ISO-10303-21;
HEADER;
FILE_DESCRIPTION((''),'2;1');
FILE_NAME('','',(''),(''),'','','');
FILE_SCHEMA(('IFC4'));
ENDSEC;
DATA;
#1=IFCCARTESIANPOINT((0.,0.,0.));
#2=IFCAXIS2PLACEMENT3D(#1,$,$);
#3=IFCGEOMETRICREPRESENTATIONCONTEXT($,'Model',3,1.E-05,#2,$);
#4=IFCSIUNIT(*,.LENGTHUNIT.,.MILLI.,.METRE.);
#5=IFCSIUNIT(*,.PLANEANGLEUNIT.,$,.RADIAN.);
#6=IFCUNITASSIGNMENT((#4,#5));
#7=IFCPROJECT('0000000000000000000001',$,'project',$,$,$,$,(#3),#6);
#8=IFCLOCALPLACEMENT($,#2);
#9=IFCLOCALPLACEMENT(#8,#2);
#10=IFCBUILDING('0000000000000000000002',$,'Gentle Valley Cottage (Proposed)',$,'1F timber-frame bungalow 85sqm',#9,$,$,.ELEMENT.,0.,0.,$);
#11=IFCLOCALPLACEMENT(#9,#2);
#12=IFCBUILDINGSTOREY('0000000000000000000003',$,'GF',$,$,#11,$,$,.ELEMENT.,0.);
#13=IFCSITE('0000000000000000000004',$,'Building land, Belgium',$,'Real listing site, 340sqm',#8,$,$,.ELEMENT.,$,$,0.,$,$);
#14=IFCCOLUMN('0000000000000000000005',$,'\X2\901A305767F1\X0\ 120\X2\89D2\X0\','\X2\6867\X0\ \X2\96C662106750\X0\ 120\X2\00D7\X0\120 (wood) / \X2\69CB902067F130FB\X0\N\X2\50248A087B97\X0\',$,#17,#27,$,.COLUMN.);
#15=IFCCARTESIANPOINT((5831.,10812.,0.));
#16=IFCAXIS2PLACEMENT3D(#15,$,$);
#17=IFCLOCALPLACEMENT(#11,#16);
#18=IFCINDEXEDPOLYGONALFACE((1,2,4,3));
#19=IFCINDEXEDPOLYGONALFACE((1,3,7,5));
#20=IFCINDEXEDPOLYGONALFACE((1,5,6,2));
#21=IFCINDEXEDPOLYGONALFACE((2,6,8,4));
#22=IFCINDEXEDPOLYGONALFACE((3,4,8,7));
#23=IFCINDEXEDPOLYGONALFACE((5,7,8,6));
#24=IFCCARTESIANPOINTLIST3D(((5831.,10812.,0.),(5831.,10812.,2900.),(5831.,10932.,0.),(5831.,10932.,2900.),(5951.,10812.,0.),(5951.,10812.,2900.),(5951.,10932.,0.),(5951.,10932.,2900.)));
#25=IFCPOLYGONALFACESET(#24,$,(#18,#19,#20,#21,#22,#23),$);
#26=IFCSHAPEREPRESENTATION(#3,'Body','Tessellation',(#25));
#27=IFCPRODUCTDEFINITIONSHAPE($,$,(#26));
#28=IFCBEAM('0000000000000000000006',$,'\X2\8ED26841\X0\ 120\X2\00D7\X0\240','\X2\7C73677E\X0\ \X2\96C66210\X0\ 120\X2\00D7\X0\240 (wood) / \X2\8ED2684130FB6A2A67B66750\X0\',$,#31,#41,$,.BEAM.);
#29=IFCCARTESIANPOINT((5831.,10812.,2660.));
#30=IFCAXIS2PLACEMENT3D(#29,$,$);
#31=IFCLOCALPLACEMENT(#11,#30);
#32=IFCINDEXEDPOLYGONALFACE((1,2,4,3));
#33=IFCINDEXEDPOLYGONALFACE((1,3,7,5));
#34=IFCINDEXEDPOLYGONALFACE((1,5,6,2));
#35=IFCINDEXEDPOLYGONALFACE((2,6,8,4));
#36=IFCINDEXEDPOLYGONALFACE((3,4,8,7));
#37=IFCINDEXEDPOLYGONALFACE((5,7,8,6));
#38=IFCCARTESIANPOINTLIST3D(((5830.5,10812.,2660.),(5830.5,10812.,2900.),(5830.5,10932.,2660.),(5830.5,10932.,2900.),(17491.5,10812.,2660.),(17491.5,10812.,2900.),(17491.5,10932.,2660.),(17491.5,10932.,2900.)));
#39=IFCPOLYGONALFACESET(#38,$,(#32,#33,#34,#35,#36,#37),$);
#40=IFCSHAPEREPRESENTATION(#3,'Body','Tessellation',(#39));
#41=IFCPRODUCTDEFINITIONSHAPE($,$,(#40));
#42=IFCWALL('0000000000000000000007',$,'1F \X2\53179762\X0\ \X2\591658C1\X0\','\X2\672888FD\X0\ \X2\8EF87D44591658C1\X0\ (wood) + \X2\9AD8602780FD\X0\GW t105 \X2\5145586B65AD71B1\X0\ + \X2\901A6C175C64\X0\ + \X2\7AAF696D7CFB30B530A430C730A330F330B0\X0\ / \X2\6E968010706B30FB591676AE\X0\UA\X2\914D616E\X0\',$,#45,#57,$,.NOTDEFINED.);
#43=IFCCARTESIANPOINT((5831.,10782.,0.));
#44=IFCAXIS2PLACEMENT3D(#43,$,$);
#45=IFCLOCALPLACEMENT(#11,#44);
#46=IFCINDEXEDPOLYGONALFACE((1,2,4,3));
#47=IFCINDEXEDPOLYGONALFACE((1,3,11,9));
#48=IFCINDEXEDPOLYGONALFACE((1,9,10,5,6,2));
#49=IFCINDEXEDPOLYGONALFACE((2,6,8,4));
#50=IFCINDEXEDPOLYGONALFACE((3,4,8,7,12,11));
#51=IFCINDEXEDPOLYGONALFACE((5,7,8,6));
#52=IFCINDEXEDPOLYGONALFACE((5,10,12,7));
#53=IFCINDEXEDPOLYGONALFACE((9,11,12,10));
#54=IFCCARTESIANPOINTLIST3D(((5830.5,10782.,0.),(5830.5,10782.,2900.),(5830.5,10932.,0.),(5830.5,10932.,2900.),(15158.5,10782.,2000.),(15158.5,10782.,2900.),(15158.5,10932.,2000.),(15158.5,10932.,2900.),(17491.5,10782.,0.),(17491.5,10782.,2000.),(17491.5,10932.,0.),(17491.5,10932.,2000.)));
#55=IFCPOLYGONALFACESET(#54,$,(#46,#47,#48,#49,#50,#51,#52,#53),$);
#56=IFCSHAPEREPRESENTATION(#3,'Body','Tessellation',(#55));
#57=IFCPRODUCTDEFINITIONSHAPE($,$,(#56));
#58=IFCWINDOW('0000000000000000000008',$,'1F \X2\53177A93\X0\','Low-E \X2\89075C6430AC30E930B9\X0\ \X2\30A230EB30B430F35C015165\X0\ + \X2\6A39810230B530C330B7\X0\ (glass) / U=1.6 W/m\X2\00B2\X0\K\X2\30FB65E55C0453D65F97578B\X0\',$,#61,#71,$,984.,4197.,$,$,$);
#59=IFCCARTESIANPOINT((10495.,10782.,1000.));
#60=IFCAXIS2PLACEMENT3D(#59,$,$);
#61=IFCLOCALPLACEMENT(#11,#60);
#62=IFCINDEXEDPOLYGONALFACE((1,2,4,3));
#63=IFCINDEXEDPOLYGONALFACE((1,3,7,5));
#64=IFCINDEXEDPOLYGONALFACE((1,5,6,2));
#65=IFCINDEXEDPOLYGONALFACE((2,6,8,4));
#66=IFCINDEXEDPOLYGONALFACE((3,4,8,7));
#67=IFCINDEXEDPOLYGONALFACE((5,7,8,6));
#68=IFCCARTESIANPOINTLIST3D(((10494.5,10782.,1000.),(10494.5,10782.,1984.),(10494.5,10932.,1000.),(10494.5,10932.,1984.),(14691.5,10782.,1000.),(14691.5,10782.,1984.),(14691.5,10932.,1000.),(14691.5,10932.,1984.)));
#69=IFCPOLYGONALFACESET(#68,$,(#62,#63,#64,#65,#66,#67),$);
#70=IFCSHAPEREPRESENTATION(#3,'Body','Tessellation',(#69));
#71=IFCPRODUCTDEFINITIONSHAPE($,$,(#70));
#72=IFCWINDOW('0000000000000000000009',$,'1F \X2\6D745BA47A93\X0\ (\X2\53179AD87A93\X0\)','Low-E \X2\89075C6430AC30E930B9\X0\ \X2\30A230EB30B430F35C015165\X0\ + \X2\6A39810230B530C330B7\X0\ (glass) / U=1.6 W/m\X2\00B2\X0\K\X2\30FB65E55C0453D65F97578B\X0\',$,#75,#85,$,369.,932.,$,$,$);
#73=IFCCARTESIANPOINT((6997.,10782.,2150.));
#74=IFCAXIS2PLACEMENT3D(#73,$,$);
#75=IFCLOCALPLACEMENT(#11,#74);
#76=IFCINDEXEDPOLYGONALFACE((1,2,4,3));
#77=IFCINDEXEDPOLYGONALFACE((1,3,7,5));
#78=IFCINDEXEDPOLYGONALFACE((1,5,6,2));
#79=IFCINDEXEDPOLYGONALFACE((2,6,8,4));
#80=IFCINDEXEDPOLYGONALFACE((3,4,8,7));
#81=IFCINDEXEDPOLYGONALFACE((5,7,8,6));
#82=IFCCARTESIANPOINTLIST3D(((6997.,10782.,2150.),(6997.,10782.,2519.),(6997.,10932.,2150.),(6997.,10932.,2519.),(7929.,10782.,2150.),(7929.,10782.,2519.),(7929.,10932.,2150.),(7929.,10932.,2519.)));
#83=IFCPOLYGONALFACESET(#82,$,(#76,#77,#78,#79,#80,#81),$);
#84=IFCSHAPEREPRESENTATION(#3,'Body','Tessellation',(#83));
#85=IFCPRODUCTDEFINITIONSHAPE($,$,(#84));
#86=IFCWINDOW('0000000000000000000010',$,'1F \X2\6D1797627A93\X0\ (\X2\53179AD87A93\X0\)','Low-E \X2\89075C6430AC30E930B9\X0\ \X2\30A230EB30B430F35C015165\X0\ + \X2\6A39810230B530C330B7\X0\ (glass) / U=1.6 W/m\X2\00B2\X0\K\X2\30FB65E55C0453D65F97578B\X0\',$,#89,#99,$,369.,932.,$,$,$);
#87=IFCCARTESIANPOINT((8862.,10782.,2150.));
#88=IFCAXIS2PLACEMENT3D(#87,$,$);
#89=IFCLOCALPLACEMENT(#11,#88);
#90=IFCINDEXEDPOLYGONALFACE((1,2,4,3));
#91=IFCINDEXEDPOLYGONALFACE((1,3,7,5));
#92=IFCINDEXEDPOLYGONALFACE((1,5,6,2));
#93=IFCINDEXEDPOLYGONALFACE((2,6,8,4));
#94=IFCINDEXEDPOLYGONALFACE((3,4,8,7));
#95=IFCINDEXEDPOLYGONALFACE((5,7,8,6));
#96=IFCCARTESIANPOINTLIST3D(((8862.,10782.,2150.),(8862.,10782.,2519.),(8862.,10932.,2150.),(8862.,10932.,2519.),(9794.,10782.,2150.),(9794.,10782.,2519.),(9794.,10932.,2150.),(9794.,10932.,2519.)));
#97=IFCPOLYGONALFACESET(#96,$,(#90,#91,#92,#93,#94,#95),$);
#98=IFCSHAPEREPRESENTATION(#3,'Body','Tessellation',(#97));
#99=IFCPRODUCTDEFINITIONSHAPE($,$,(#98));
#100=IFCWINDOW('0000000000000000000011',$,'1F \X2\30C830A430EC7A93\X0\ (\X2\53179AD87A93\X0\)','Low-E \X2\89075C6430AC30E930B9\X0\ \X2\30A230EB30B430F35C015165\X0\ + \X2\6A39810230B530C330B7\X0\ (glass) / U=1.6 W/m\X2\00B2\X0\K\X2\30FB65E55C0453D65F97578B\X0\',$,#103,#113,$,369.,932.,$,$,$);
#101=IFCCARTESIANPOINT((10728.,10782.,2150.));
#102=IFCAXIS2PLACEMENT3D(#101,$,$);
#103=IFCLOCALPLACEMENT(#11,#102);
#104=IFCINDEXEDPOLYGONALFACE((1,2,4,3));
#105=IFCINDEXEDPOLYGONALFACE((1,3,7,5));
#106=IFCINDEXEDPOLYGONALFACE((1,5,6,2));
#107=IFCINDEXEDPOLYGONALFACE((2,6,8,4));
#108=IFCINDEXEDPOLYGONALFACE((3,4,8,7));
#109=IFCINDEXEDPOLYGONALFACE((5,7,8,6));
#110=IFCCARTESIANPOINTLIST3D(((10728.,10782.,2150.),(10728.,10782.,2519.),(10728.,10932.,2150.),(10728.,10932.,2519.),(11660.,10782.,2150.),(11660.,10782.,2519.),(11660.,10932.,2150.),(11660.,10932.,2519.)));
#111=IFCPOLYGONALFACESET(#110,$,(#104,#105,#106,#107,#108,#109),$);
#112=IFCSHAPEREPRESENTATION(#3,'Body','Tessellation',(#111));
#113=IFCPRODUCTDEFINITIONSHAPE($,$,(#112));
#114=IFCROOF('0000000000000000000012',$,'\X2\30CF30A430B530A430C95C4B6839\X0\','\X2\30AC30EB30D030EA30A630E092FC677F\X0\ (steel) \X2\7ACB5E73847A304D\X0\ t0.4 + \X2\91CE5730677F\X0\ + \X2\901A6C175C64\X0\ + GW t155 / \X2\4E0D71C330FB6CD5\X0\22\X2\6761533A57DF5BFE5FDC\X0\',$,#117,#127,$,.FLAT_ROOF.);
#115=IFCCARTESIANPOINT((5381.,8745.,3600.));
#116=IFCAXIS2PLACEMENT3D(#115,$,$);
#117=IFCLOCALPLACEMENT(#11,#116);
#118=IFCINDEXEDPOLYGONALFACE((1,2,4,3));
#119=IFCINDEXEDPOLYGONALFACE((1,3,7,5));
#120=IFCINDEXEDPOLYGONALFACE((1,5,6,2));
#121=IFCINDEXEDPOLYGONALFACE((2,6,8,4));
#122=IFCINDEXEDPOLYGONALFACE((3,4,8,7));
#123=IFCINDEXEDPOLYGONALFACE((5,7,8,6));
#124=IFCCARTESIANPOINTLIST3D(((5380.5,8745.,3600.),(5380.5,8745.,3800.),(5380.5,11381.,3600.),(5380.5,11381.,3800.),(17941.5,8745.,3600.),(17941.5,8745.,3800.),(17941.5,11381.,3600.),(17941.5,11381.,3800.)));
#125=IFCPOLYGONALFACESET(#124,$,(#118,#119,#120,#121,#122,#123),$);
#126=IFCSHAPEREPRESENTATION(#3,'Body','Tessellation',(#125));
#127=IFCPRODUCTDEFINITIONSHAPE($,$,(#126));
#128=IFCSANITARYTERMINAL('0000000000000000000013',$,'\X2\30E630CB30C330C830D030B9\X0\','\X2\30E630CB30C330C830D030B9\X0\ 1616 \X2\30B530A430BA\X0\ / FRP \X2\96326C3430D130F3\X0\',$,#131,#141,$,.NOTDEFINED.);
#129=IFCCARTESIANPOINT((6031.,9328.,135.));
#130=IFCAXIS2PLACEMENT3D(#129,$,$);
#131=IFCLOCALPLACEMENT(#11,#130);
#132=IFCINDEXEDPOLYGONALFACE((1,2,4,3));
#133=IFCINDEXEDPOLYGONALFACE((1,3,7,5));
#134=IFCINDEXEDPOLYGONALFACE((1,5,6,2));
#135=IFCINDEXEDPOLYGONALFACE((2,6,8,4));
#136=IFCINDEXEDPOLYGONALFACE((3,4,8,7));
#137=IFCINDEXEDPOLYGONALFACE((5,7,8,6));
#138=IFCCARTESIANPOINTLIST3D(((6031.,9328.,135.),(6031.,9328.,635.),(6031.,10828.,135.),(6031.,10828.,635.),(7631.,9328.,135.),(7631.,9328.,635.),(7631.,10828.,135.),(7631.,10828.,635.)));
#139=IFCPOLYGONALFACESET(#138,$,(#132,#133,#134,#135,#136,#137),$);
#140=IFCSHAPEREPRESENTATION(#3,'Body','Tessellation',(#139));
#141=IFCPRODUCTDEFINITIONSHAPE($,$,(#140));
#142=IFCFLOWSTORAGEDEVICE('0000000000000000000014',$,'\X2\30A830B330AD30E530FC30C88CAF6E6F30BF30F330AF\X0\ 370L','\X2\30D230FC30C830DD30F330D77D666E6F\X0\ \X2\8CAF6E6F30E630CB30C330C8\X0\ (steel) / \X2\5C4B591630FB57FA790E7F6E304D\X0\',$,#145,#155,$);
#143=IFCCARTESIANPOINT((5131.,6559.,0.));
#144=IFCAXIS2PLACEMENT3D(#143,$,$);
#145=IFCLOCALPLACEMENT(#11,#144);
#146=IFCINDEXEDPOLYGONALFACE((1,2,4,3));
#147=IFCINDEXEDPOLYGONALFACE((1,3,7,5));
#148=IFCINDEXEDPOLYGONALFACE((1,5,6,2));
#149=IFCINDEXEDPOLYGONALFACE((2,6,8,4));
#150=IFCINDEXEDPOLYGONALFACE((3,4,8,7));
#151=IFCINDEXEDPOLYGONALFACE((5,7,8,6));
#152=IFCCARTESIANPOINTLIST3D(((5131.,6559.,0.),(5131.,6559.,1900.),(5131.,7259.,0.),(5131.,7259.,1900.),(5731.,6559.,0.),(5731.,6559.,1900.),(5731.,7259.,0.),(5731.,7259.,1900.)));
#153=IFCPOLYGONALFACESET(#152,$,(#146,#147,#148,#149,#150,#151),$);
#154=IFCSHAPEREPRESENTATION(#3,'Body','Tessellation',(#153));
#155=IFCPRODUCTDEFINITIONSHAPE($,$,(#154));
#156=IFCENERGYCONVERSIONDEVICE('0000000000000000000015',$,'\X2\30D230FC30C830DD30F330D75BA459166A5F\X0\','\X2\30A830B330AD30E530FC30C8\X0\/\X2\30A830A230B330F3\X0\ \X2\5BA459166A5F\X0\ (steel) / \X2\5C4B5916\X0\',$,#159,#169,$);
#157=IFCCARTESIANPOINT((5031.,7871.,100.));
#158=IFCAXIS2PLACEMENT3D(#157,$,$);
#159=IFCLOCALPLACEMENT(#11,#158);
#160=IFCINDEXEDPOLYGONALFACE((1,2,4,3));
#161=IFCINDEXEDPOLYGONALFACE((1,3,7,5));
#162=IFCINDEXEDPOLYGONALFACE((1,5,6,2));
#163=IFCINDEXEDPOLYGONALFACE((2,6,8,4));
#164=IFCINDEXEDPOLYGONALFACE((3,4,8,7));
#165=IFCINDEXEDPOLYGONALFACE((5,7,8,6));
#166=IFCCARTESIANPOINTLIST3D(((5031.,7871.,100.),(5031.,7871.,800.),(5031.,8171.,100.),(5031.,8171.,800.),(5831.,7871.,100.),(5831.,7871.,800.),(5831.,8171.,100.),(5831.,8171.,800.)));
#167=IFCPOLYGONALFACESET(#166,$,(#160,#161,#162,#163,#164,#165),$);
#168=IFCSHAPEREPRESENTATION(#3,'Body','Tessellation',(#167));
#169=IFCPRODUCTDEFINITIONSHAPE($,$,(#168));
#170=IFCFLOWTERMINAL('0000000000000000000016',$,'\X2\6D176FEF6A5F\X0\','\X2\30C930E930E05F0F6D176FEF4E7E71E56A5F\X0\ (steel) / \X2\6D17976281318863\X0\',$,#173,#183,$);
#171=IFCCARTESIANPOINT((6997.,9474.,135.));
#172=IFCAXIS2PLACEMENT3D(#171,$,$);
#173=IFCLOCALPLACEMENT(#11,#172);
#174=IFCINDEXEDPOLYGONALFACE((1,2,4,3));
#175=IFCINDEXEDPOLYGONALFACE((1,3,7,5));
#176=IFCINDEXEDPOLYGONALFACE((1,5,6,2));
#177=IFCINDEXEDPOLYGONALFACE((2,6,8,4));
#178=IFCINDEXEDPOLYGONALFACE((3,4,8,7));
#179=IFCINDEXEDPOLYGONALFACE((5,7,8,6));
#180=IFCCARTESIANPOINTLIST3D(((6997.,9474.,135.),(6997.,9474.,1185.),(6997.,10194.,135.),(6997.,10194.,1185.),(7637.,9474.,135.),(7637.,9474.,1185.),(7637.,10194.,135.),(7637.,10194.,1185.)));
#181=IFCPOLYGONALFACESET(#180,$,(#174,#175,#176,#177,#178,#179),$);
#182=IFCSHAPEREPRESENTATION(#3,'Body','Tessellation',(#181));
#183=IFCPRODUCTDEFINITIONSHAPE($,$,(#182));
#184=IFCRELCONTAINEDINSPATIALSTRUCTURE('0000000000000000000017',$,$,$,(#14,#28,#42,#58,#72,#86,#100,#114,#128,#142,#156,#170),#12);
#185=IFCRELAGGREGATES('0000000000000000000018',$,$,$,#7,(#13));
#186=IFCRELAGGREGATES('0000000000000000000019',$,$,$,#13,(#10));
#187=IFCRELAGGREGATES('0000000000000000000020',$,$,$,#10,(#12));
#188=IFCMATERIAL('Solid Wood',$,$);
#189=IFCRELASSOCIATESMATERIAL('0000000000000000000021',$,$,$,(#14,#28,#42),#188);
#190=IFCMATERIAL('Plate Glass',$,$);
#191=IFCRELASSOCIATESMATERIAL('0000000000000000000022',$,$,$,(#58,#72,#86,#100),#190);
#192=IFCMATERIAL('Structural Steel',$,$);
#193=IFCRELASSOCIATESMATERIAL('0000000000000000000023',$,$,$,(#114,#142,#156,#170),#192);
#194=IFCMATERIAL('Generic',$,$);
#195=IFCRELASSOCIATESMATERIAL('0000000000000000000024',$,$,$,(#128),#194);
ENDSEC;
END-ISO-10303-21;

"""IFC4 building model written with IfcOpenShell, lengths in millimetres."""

from ifc_helpers import new_model, si_unit, frame, frame_2d, origin, place, context, project, spatial, rectangle, extrude, material, element, fill, save


model = new_model("IFC4")

# Units and contexts
model_context = context("Model", 3, precision=1e-05, world=origin())
ifc_project = project(units=[si_unit("LENGTHUNIT", "METRE", prefix="MILLI"), si_unit("PLANEANGLEUNIT", "RADIAN")], contexts=[model_context])

# Site, building, storey
site_placement = place(None, origin())
site = spatial("IfcSite", under=ifc_project, at=site_placement, Name="Building land, Belgium", ObjectType="Real listing site, 340sqm", CompositionType="ELEMENT", RefElevation=0.0)
building_placement = place(site_placement, origin())
building = spatial("IfcBuilding", under=site, at=building_placement, Name="Gentle Valley Cottage (Proposed)", ObjectType="1F timber-frame bungalow 85sqm", CompositionType="ELEMENT", ElevationOfRefHeight=0.0, ElevationOfTerrain=0.0)
storey_placement = place(building_placement, origin())
storey = spatial("IfcBuildingStorey", under=building, at=storey_placement, Name="GF", CompositionType="ELEMENT", Elevation=0.0)

# Column
ifc_material_1 = material(Name="Solid Wood")
column_1_placement = place(storey_placement, frame((5831.0, 10812.0, 0.0)))
element("IfcColumn", 1, at=column_1_placement, inside=storey, material=ifc_material_1, Name="通し柱 120角", Description="桧 集成材 120×120 (wood) / 構造柱・N値計算", PredefinedType="COLUMN", context=model_context, shape_type="SweptSolid", body=[
    extrude(rectangle(XDim=120.0, YDim=120.0, at=frame_2d((60.0, 60.0))), frame((5831.0, 10812.0, 0.0)), (0.0, 0.0, 1.0), 2900.0),
])

# Beam
beam_1_placement = place(storey_placement, frame((5831.0, 10812.0, 2660.0)))
element("IfcBeam", 2, at=beam_1_placement, inside=storey, material=ifc_material_1, Name="軒桁 120×240", Description="米松 集成 120×240 (wood) / 軒桁・横架材", PredefinedType="BEAM", context=model_context, shape_type="SweptSolid", body=[
    extrude(rectangle(XDim=11661.0, YDim=120.0, at=frame_2d((5830.0, 60.0))), frame((5831.0, 10812.0, 2660.0)), (0.0, 0.0, 1.0), 240.0),
])

# Wall, openings, windows
wall_1_placement = place(storey_placement, frame((5831.0, 10782.0, 0.0)))
wall_1 = element("IfcWall", 3, at=wall_1_placement, inside=storey, material=ifc_material_1, Name="1F 北面 外壁", Description="木製 軸組外壁 (wood) + 高性能GW t105 充填断熱 + 通気層 + 窯業系サイディング / 準耐火・外皮UA配慮", PredefinedType="NOTDEFINED", context=model_context, shape_type="SweptSolid", body=[
    extrude(rectangle(XDim=11661.0, YDim=150.0, at=frame_2d((5830.0, 75.0))), frame((5831.0, 10782.0, 0.0)), (0.0, 0.0, 1.0), 2900.0),
])
opening_1_placement = place(storey_placement, frame((10495.0, 10782.0, 1000.0)))
opening_1 = element("IfcOpeningElement", 4, at=opening_1_placement, cuts=wall_1, PredefinedType="NOTDEFINED", context=model_context, shape_type="SweptSolid", body=[
    extrude(rectangle(XDim=4197.0, YDim=150.0, at=frame_2d((2098.0, 75.0))), frame((10495.0, 10782.0, 1000.0)), (0.0, 0.0, 1.0), 984.0),
])
opening_2_placement = place(storey_placement, frame((6997.0, 10782.0, 2150.0)))
opening_2 = element("IfcOpeningElement", 5, at=opening_2_placement, cuts=wall_1, PredefinedType="NOTDEFINED", context=model_context, shape_type="SweptSolid", body=[
    extrude(rectangle(XDim=932.0, YDim=150.0, at=frame_2d((466.0, 75.0))), frame((6997.0, 10782.0, 2150.0)), (0.0, 0.0, 1.0), 369.0),
])
opening_3_placement = place(storey_placement, frame((8862.0, 10782.0, 2150.0)))
opening_3 = element("IfcOpeningElement", 6, at=opening_3_placement, cuts=wall_1, PredefinedType="NOTDEFINED", context=model_context, shape_type="SweptSolid", body=[
    extrude(rectangle(XDim=932.0, YDim=150.0, at=frame_2d((466.0, 75.0))), frame((8862.0, 10782.0, 2150.0)), (0.0, 0.0, 1.0), 369.0),
])
opening_4_placement = place(storey_placement, frame((10728.0, 10782.0, 2150.0)))
opening_4 = element("IfcOpeningElement", 7, at=opening_4_placement, cuts=wall_1, PredefinedType="NOTDEFINED", context=model_context, shape_type="SweptSolid", body=[
    extrude(rectangle(XDim=932.0, YDim=150.0, at=frame_2d((466.0, 75.0))), frame((10728.0, 10782.0, 2150.0)), (0.0, 0.0, 1.0), 369.0),
])
ifc_material_2 = material(Name="Plate Glass")
window_1_placement = place(storey_placement, frame((10495.0, 10782.0, 1000.0)))
window_1 = element("IfcWindow", 8, at=window_1_placement, inside=storey, material=ifc_material_2, Name="1F 北窓", Description="Low-E 複層ガラス アルゴン封入 + 樹脂サッシ (glass) / U=1.6 W/m²K・日射取得型", OverallHeight=984.0, OverallWidth=4197.0, context=model_context, shape_type="SweptSolid", body=[
    extrude(rectangle(XDim=4197.0, YDim=150.0, at=frame_2d((2098.0, 75.0))), frame((10495.0, 10782.0, 1000.0)), (0.0, 0.0, 1.0), 984.0),
])
fill(opening_1, window_1)
window_2_placement = place(storey_placement, frame((6997.0, 10782.0, 2150.0)))
window_2 = element("IfcWindow", 9, at=window_2_placement, inside=storey, material=ifc_material_2, Name="1F 浴室窓 (北高窓)", Description="Low-E 複層ガラス アルゴン封入 + 樹脂サッシ (glass) / U=1.6 W/m²K・日射取得型", OverallHeight=369.0, OverallWidth=932.0, context=model_context, shape_type="SweptSolid", body=[
    extrude(rectangle(XDim=932.0, YDim=150.0, at=frame_2d((466.0, 75.0))), frame((6997.0, 10782.0, 2150.0)), (0.0, 0.0, 1.0), 369.0),
])
fill(opening_2, window_2)
window_3_placement = place(storey_placement, frame((8862.0, 10782.0, 2150.0)))
window_3 = element("IfcWindow", 10, at=window_3_placement, inside=storey, material=ifc_material_2, Name="1F 洗面窓 (北高窓)", Description="Low-E 複層ガラス アルゴン封入 + 樹脂サッシ (glass) / U=1.6 W/m²K・日射取得型", OverallHeight=369.0, OverallWidth=932.0, context=model_context, shape_type="SweptSolid", body=[
    extrude(rectangle(XDim=932.0, YDim=150.0, at=frame_2d((466.0, 75.0))), frame((8862.0, 10782.0, 2150.0)), (0.0, 0.0, 1.0), 369.0),
])
fill(opening_3, window_3)
window_4_placement = place(storey_placement, frame((10728.0, 10782.0, 2150.0)))
window_4 = element("IfcWindow", 11, at=window_4_placement, inside=storey, material=ifc_material_2, Name="1F トイレ窓 (北高窓)", Description="Low-E 複層ガラス アルゴン封入 + 樹脂サッシ (glass) / U=1.6 W/m²K・日射取得型", OverallHeight=369.0, OverallWidth=932.0, context=model_context, shape_type="SweptSolid", body=[
    extrude(rectangle(XDim=932.0, YDim=150.0, at=frame_2d((466.0, 75.0))), frame((10728.0, 10782.0, 2150.0)), (0.0, 0.0, 1.0), 369.0),
])
fill(opening_4, window_4)

# Roof
ifc_material_3 = material(Name="Structural Steel")
roof_placement = place(storey_placement, frame((5381.0, 8745.0, 3600.0)))
element("IfcRoof", 12, at=roof_placement, inside=storey, material=ifc_material_3, Name="ハイサイド屋根", Description="ガルバリウム鋼板 (steel) 立平葺き t0.4 + 野地板 + 通気層 + GW t155 / 不燃・法22条区域対応", PredefinedType="FLAT_ROOF", context=model_context, shape_type="SweptSolid", body=[
    extrude(rectangle(XDim=12561.0, YDim=2636.0, at=frame_2d((6280.0, 1318.0))), frame((5381.0, 8745.0, 3600.0)), (0.0, 0.0, 1.0), 200.0),
])

# Sanitary terminal
ifc_material_4 = material(Name="Generic")
sanitary_terminal_placement = place(storey_placement, frame((6031.0, 9328.0, 135.0)))
element("IfcSanitaryTerminal", 13, at=sanitary_terminal_placement, inside=storey, material=ifc_material_4, Name="ユニットバス", Description="ユニットバス 1616 サイズ / FRP 防水パン", PredefinedType="NOTDEFINED", context=model_context, shape_type="SweptSolid", body=[
    extrude(rectangle(XDim=1600.0, YDim=1500.0, at=frame_2d((800.0, 750.0))), frame((6031.0, 9328.0, 135.0)), (0.0, 0.0, 1.0), 500.0),
])

# Flow storage device
flow_storage_device_placement = place(storey_placement, frame((5131.0, 6559.0, 0.0)))
element("IfcFlowStorageDevice", 14, at=flow_storage_device_placement, inside=storey, material=ifc_material_3, Name="エコキュート貯湯タンク 370L", Description="ヒートポンプ給湯 貯湯ユニット (steel) / 屋外・基礎置き", context=model_context, shape_type="SweptSolid", body=[
    extrude(rectangle(XDim=600.0, YDim=700.0, at=frame_2d((300.0, 350.0))), frame((5131.0, 6559.0, 0.0)), (0.0, 0.0, 1.0), 1900.0),
])

# Energy conversion device
energy_conversion_device_placement = place(storey_placement, frame((5031.0, 7871.0, 100.0)))
element("IfcEnergyConversionDevice", 15, at=energy_conversion_device_placement, inside=storey, material=ifc_material_3, Name="ヒートポンプ室外機", Description="エコキュート/エアコン 室外機 (steel) / 屋外", context=model_context, shape_type="SweptSolid", body=[
    extrude(rectangle(XDim=800.0, YDim=300.0, at=frame_2d((400.0, 150.0))), frame((5031.0, 7871.0, 100.0)), (0.0, 0.0, 1.0), 700.0),
])

# Flow terminal
flow_terminal_placement = place(storey_placement, frame((6997.0, 9474.0, 135.0)))
element("IfcFlowTerminal", 16, at=flow_terminal_placement, inside=storey, material=ifc_material_3, Name="洗濯機", Description="ドラム式洗濯乾燥機 (steel) / 洗面脱衣", context=model_context, shape_type="SweptSolid", body=[
    extrude(rectangle(XDim=640.0, YDim=720.0, at=frame_2d((320.0, 360.0))), frame((6997.0, 9474.0, 135.0)), (0.0, 0.0, 1.0), 1050.0),
])

save(model, "model.ifc")
